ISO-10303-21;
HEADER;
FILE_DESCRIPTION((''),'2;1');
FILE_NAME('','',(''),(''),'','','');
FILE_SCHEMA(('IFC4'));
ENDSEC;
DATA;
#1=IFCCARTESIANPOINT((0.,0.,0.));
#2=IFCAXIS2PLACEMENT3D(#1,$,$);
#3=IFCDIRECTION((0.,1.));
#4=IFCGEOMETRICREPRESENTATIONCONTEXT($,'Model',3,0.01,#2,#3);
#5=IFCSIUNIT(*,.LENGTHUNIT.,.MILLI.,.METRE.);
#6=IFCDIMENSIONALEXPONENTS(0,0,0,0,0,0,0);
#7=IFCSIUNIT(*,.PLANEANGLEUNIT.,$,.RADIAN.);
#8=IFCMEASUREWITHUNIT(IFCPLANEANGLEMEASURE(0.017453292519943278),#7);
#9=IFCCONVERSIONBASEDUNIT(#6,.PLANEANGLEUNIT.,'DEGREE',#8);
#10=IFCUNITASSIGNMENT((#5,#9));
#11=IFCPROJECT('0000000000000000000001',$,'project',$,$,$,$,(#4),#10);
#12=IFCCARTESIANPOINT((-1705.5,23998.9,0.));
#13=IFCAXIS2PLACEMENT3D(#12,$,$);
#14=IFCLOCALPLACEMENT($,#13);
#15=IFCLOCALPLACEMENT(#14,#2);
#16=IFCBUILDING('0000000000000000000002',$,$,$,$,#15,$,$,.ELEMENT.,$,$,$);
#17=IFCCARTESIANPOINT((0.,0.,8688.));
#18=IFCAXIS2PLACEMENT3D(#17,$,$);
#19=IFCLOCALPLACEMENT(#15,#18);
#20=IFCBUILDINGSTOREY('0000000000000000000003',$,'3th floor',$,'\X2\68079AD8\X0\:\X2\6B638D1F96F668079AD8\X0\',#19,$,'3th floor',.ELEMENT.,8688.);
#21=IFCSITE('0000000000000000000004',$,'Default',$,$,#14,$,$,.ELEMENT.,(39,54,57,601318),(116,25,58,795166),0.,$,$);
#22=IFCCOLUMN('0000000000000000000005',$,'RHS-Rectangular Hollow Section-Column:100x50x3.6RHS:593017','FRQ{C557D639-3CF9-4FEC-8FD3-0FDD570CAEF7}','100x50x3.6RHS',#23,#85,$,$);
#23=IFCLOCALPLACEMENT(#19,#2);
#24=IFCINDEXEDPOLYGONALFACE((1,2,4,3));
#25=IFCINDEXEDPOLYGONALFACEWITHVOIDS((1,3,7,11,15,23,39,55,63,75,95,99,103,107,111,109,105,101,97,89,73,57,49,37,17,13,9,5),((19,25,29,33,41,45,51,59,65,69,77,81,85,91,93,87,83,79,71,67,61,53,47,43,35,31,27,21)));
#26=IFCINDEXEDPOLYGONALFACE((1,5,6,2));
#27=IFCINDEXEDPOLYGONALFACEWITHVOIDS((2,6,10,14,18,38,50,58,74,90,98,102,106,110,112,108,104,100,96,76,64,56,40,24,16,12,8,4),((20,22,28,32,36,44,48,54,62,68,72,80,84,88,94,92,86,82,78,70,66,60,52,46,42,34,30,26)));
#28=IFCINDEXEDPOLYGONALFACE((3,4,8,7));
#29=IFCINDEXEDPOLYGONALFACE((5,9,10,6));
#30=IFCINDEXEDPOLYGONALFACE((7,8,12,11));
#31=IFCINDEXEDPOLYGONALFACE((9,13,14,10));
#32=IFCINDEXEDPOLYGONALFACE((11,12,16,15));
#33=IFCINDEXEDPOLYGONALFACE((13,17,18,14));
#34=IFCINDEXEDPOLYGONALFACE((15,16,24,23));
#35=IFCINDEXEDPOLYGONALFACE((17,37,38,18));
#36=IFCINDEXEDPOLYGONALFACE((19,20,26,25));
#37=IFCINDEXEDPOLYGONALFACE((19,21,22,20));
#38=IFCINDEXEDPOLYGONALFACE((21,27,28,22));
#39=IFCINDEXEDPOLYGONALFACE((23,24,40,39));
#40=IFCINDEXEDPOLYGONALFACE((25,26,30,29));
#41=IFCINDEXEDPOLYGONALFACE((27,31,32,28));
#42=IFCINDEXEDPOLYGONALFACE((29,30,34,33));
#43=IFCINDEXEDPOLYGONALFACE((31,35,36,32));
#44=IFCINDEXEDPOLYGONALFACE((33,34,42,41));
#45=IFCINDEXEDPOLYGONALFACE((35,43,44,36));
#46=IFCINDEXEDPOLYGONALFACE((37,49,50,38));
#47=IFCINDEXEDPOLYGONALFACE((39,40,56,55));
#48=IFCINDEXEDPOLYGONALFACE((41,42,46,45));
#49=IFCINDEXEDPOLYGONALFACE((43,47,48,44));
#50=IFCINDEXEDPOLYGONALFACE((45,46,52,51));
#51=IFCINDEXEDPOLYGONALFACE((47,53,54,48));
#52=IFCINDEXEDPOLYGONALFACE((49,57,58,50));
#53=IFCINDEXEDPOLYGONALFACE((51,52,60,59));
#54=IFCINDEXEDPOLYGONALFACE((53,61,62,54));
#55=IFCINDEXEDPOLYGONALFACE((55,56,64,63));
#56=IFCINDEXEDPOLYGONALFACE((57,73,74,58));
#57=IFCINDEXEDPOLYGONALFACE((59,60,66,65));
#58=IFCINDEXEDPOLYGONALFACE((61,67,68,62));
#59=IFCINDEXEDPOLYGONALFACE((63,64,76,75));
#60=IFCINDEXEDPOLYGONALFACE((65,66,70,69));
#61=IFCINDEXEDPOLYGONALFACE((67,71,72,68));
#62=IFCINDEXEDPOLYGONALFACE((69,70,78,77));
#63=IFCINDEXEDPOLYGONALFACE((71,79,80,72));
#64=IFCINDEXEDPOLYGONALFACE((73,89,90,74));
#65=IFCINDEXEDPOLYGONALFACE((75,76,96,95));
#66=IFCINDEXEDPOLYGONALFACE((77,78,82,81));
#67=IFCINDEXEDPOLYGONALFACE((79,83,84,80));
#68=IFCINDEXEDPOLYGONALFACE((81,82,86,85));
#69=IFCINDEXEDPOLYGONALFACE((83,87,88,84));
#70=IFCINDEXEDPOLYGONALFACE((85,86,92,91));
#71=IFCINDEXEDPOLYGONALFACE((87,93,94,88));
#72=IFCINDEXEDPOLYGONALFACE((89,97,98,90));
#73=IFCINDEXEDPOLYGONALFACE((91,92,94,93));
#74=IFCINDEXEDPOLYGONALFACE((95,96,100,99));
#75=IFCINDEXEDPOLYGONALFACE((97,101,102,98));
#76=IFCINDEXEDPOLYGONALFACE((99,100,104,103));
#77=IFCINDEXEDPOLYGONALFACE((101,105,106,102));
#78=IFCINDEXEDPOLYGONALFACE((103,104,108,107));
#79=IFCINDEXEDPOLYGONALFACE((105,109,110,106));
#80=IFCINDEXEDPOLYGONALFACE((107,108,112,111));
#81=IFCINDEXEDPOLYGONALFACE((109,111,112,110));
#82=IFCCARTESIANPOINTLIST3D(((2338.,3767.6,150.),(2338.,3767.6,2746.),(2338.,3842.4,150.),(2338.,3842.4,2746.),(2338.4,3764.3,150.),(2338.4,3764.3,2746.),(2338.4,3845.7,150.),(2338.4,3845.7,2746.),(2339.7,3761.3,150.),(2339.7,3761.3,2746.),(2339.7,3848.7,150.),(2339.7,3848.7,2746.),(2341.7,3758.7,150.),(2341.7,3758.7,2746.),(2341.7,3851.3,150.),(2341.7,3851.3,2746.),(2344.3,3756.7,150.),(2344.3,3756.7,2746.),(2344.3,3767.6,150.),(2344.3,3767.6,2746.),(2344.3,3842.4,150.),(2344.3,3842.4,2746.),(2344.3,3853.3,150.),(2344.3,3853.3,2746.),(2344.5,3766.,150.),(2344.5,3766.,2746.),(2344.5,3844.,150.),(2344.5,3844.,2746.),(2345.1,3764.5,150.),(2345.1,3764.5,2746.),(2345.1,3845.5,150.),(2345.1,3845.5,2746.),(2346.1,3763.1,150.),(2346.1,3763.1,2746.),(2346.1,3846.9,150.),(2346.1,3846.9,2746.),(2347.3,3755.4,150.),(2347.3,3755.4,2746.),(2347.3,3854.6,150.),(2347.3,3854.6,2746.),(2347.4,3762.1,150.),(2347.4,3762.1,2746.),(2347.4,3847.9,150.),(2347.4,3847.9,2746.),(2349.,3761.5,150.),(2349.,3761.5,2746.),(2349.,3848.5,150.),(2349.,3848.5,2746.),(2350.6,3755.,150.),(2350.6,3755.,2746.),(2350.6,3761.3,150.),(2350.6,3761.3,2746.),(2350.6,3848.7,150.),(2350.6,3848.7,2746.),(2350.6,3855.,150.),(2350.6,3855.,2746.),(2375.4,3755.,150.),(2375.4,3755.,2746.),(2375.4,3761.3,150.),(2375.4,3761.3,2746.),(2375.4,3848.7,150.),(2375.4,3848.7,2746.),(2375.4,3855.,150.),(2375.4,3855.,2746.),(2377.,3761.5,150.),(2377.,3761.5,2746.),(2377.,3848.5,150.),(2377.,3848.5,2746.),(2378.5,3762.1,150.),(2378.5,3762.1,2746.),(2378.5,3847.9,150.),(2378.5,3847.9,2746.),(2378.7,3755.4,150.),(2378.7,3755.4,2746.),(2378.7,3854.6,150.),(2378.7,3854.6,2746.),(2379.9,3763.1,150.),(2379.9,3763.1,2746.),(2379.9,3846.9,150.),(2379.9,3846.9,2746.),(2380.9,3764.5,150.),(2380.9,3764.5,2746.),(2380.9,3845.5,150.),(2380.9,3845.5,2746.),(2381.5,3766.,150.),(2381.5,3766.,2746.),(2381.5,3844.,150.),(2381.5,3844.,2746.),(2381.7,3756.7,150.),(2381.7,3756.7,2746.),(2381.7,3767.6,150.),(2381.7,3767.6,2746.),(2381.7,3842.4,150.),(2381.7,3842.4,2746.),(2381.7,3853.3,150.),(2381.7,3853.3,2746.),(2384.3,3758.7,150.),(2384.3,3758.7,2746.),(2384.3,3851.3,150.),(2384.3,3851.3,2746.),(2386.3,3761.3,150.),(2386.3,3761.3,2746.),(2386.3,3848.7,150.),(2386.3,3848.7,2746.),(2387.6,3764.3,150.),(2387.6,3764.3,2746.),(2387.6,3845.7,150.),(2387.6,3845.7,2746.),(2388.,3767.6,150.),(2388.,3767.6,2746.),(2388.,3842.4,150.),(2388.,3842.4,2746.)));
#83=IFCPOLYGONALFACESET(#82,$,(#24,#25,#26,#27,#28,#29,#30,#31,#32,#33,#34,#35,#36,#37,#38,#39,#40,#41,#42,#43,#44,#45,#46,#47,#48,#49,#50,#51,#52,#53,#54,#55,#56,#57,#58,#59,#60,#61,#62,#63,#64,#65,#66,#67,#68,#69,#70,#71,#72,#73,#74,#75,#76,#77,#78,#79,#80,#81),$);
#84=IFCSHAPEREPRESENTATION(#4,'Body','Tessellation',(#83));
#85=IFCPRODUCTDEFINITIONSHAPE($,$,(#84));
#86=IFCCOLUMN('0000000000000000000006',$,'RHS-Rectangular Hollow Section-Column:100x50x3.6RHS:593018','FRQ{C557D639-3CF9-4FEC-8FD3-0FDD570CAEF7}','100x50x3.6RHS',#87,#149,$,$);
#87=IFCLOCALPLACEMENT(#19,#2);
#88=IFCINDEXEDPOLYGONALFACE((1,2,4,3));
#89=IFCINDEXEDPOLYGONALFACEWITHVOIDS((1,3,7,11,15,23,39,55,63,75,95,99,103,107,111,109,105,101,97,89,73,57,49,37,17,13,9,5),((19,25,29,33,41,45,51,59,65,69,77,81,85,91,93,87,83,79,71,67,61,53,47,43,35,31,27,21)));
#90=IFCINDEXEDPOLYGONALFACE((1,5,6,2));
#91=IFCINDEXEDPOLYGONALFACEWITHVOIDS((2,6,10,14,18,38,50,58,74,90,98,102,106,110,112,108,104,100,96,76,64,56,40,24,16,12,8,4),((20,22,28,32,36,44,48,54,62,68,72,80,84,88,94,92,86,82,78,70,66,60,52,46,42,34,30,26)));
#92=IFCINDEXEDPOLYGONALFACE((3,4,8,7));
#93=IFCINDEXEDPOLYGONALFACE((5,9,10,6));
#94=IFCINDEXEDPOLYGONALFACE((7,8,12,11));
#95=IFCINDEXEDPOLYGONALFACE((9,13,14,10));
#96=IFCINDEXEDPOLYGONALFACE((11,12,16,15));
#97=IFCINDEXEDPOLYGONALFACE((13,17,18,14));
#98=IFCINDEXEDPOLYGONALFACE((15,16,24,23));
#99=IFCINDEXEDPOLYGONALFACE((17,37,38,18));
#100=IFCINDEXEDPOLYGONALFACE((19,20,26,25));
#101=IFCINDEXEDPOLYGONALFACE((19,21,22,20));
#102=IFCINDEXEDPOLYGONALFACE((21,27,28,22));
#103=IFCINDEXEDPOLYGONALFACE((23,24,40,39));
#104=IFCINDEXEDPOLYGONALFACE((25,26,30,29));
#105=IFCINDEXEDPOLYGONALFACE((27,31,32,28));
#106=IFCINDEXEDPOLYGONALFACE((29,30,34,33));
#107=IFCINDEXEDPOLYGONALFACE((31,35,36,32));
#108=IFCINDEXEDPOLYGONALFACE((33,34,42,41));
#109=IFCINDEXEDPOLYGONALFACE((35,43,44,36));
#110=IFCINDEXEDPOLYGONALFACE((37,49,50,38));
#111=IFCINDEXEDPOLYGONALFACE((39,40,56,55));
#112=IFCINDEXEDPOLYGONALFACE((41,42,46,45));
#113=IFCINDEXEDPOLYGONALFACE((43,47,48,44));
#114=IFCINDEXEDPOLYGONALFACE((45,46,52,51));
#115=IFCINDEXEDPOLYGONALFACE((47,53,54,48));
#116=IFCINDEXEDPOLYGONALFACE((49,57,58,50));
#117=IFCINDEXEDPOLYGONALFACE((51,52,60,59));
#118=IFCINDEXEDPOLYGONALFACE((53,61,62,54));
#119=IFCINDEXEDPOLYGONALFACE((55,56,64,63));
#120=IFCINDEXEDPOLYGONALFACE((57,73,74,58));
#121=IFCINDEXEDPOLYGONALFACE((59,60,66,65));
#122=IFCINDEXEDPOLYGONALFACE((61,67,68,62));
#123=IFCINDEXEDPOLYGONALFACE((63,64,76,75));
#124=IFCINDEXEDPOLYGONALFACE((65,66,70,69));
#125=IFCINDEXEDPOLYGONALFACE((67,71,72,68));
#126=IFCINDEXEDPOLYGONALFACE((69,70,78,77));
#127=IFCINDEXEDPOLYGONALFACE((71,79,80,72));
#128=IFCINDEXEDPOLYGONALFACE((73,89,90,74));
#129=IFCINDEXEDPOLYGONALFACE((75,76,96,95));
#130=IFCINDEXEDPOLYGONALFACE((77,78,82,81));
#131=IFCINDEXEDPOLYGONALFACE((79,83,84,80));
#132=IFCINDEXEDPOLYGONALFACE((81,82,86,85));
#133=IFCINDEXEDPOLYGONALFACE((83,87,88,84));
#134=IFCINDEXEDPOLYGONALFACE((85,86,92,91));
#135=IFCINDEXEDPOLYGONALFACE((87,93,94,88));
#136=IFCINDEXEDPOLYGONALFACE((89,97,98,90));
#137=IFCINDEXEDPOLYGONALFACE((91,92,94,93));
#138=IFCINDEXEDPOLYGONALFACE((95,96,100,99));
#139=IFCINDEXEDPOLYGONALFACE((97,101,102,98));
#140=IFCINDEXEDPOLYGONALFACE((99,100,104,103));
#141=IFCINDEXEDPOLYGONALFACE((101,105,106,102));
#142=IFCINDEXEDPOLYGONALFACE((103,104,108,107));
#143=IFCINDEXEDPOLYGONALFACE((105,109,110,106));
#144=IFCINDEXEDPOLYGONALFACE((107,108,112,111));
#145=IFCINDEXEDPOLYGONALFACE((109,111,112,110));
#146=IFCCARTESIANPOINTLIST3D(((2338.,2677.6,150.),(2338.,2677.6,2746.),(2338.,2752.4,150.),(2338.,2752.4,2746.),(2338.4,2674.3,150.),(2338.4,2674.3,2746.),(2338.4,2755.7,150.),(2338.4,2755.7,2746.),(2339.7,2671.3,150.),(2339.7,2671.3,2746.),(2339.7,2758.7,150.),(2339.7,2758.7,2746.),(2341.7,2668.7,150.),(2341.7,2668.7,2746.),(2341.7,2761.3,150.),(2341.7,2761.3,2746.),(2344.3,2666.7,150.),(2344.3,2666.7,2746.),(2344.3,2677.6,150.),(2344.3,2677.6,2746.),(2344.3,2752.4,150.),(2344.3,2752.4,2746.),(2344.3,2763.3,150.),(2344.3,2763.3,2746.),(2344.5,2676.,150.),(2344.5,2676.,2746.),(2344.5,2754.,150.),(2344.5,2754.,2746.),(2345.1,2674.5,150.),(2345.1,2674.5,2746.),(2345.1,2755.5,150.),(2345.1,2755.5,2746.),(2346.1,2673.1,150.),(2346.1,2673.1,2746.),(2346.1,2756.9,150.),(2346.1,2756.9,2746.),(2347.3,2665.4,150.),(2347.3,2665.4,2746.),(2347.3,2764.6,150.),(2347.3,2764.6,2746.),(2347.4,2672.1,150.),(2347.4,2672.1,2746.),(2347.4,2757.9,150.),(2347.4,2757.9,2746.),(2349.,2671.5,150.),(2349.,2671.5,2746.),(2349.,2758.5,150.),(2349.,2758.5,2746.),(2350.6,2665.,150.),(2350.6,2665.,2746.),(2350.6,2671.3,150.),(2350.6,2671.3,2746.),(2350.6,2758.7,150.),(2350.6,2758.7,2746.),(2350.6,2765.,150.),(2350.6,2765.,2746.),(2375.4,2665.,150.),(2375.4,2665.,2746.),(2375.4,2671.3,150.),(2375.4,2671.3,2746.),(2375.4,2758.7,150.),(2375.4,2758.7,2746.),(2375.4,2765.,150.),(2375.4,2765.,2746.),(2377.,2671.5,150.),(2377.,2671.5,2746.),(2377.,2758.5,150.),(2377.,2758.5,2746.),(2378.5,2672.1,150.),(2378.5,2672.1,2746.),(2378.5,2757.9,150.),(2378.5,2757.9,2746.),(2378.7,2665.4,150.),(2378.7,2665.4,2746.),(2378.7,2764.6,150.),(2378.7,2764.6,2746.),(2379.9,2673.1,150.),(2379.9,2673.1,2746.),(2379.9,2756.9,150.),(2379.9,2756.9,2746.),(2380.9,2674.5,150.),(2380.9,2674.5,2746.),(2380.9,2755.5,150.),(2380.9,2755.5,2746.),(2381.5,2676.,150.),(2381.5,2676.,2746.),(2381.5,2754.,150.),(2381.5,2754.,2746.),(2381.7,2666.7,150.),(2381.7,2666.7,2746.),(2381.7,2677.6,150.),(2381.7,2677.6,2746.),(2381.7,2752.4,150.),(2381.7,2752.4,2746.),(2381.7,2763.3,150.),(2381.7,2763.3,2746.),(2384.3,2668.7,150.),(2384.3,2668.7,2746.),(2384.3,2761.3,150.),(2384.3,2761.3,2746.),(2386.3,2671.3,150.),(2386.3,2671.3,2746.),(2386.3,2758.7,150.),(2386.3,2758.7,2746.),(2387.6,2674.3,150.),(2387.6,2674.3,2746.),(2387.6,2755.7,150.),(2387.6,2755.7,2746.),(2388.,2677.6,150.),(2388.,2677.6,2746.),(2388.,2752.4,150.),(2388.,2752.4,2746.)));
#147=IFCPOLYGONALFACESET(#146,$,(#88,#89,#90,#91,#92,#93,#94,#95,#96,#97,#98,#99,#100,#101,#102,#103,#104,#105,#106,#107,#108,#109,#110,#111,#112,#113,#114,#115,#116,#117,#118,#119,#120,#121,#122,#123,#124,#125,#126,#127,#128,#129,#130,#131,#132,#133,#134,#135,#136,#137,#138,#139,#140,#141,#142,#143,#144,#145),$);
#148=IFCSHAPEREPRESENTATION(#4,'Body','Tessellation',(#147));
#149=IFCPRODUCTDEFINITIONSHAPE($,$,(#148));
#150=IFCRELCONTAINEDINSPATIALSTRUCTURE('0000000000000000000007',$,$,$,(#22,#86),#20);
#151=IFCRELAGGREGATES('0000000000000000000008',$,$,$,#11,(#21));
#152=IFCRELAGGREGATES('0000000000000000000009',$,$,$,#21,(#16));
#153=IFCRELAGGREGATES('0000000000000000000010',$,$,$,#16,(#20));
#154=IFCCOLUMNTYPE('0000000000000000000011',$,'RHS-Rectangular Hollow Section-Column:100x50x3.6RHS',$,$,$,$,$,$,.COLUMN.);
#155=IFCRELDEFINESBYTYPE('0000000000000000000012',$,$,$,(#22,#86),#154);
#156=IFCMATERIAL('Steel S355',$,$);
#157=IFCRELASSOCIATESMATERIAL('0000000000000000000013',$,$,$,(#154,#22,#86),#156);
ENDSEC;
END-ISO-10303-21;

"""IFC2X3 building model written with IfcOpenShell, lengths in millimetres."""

from ifc_helpers import new_model, entity, si_unit, converted_unit, direction, frame, origin, origin_2d, place, context, project, spatial, hollow_rectangle, extrude, clip, halfspace, material, type_object, element, save


model = new_model("IFC2X3")

# Units and contexts
model_context = context("Model", 3, precision=0.01, world=origin(), true_north=direction((0.0, 1.0)))
ifc_project = project(units=[si_unit("LENGTHUNIT", "METRE", prefix="MILLI"), converted_unit("PLANEANGLEUNIT", "DEGREE", entity("IfcPlaneAngleMeasure", 0.017453292519943278), si_unit("PLANEANGLEUNIT", "RADIAN"), dimensions=[0, 0, 0, 0, 0, 0, 0])], contexts=[model_context])

# Site, building, storey
site_placement = place(None, frame((-1705.5, 23998.9, 0.0)))
site = spatial("IfcSite", under=ifc_project, at=site_placement, Name="Default", CompositionType="ELEMENT", RefLatitude=(39, 54, 57, 601318), RefLongitude=(116, 25, 58, 795166), RefElevation=0.0)
building_placement = place(site_placement, origin())
building = spatial("IfcBuilding", under=site, at=building_placement, CompositionType="ELEMENT")
storey_placement = place(building_placement, frame((0.0, 0.0, 8688.0)))
storey = spatial("IfcBuildingStorey", under=building, at=storey_placement, Name="3th floor", ObjectType="标高:正负零标高", LongName="3th floor", CompositionType="ELEMENT", Elevation=8688.0)

# Columns
ifc_material_1 = material(Name="Steel S355")
column_type_1 = type_object("IfcColumnType", Name="RHS-Rectangular Hollow Section-Column:100x50x3.6RHS", PredefinedType="COLUMN", material=ifc_material_1)
column_1_placement = place(storey_placement, frame((2363.0, 3805.0, 2746.0), z_axis=(0.0, 0.0, 1.0), x_axis=(-1.0, 0.0, 0.0)))
element("IfcColumn", 1, at=column_1_placement, inside=storey, type_object=column_type_1, material=ifc_material_1, Name="RHS-Rectangular Hollow Section-Column:100x50x3.6RHS:593017", Description="FRQ{C557D639-3CF9-4FEC-8FD3-0FDD570CAEF7}", ObjectType="100x50x3.6RHS", context=model_context, shape_type="Clipping", body=[
    clip(extrude(hollow_rectangle(XDim=50.0, YDim=100.0, WallThickness=6.3, InnerFilletRadius=6.3, OuterFilletRadius=12.6, at=origin_2d()), origin(), (0.0, 0.0, -1.0), 2651.9), halfspace(frame((2363.0, 3805.0, -2596.0), z_axis=(0.0, 0.0, 1.0), x_axis=(-1.0, 0.0, 0.0)), True)),
])
column_2_placement = place(storey_placement, frame((2363.0, 2715.0, 2746.0), z_axis=(0.0, 0.0, 1.0), x_axis=(-1.0, 0.0, 0.0)))
element("IfcColumn", 2, at=column_2_placement, inside=storey, type_object=column_type_1, material=ifc_material_1, Name="RHS-Rectangular Hollow Section-Column:100x50x3.6RHS:593018", Description="FRQ{C557D639-3CF9-4FEC-8FD3-0FDD570CAEF7}", ObjectType="100x50x3.6RHS", context=model_context, shape_type="Clipping", body=[
    clip(extrude(hollow_rectangle(XDim=50.0, YDim=100.0, WallThickness=6.3, InnerFilletRadius=6.3, OuterFilletRadius=12.6, at=origin_2d()), origin(), (0.0, 0.0, -1.0), 2651.9), halfspace(frame((2363.0, 2715.0, -2596.0), z_axis=(0.0, 0.0, 1.0), x_axis=(-1.0, 0.0, 0.0)), True)),
])

save(model, "model.ifc")
